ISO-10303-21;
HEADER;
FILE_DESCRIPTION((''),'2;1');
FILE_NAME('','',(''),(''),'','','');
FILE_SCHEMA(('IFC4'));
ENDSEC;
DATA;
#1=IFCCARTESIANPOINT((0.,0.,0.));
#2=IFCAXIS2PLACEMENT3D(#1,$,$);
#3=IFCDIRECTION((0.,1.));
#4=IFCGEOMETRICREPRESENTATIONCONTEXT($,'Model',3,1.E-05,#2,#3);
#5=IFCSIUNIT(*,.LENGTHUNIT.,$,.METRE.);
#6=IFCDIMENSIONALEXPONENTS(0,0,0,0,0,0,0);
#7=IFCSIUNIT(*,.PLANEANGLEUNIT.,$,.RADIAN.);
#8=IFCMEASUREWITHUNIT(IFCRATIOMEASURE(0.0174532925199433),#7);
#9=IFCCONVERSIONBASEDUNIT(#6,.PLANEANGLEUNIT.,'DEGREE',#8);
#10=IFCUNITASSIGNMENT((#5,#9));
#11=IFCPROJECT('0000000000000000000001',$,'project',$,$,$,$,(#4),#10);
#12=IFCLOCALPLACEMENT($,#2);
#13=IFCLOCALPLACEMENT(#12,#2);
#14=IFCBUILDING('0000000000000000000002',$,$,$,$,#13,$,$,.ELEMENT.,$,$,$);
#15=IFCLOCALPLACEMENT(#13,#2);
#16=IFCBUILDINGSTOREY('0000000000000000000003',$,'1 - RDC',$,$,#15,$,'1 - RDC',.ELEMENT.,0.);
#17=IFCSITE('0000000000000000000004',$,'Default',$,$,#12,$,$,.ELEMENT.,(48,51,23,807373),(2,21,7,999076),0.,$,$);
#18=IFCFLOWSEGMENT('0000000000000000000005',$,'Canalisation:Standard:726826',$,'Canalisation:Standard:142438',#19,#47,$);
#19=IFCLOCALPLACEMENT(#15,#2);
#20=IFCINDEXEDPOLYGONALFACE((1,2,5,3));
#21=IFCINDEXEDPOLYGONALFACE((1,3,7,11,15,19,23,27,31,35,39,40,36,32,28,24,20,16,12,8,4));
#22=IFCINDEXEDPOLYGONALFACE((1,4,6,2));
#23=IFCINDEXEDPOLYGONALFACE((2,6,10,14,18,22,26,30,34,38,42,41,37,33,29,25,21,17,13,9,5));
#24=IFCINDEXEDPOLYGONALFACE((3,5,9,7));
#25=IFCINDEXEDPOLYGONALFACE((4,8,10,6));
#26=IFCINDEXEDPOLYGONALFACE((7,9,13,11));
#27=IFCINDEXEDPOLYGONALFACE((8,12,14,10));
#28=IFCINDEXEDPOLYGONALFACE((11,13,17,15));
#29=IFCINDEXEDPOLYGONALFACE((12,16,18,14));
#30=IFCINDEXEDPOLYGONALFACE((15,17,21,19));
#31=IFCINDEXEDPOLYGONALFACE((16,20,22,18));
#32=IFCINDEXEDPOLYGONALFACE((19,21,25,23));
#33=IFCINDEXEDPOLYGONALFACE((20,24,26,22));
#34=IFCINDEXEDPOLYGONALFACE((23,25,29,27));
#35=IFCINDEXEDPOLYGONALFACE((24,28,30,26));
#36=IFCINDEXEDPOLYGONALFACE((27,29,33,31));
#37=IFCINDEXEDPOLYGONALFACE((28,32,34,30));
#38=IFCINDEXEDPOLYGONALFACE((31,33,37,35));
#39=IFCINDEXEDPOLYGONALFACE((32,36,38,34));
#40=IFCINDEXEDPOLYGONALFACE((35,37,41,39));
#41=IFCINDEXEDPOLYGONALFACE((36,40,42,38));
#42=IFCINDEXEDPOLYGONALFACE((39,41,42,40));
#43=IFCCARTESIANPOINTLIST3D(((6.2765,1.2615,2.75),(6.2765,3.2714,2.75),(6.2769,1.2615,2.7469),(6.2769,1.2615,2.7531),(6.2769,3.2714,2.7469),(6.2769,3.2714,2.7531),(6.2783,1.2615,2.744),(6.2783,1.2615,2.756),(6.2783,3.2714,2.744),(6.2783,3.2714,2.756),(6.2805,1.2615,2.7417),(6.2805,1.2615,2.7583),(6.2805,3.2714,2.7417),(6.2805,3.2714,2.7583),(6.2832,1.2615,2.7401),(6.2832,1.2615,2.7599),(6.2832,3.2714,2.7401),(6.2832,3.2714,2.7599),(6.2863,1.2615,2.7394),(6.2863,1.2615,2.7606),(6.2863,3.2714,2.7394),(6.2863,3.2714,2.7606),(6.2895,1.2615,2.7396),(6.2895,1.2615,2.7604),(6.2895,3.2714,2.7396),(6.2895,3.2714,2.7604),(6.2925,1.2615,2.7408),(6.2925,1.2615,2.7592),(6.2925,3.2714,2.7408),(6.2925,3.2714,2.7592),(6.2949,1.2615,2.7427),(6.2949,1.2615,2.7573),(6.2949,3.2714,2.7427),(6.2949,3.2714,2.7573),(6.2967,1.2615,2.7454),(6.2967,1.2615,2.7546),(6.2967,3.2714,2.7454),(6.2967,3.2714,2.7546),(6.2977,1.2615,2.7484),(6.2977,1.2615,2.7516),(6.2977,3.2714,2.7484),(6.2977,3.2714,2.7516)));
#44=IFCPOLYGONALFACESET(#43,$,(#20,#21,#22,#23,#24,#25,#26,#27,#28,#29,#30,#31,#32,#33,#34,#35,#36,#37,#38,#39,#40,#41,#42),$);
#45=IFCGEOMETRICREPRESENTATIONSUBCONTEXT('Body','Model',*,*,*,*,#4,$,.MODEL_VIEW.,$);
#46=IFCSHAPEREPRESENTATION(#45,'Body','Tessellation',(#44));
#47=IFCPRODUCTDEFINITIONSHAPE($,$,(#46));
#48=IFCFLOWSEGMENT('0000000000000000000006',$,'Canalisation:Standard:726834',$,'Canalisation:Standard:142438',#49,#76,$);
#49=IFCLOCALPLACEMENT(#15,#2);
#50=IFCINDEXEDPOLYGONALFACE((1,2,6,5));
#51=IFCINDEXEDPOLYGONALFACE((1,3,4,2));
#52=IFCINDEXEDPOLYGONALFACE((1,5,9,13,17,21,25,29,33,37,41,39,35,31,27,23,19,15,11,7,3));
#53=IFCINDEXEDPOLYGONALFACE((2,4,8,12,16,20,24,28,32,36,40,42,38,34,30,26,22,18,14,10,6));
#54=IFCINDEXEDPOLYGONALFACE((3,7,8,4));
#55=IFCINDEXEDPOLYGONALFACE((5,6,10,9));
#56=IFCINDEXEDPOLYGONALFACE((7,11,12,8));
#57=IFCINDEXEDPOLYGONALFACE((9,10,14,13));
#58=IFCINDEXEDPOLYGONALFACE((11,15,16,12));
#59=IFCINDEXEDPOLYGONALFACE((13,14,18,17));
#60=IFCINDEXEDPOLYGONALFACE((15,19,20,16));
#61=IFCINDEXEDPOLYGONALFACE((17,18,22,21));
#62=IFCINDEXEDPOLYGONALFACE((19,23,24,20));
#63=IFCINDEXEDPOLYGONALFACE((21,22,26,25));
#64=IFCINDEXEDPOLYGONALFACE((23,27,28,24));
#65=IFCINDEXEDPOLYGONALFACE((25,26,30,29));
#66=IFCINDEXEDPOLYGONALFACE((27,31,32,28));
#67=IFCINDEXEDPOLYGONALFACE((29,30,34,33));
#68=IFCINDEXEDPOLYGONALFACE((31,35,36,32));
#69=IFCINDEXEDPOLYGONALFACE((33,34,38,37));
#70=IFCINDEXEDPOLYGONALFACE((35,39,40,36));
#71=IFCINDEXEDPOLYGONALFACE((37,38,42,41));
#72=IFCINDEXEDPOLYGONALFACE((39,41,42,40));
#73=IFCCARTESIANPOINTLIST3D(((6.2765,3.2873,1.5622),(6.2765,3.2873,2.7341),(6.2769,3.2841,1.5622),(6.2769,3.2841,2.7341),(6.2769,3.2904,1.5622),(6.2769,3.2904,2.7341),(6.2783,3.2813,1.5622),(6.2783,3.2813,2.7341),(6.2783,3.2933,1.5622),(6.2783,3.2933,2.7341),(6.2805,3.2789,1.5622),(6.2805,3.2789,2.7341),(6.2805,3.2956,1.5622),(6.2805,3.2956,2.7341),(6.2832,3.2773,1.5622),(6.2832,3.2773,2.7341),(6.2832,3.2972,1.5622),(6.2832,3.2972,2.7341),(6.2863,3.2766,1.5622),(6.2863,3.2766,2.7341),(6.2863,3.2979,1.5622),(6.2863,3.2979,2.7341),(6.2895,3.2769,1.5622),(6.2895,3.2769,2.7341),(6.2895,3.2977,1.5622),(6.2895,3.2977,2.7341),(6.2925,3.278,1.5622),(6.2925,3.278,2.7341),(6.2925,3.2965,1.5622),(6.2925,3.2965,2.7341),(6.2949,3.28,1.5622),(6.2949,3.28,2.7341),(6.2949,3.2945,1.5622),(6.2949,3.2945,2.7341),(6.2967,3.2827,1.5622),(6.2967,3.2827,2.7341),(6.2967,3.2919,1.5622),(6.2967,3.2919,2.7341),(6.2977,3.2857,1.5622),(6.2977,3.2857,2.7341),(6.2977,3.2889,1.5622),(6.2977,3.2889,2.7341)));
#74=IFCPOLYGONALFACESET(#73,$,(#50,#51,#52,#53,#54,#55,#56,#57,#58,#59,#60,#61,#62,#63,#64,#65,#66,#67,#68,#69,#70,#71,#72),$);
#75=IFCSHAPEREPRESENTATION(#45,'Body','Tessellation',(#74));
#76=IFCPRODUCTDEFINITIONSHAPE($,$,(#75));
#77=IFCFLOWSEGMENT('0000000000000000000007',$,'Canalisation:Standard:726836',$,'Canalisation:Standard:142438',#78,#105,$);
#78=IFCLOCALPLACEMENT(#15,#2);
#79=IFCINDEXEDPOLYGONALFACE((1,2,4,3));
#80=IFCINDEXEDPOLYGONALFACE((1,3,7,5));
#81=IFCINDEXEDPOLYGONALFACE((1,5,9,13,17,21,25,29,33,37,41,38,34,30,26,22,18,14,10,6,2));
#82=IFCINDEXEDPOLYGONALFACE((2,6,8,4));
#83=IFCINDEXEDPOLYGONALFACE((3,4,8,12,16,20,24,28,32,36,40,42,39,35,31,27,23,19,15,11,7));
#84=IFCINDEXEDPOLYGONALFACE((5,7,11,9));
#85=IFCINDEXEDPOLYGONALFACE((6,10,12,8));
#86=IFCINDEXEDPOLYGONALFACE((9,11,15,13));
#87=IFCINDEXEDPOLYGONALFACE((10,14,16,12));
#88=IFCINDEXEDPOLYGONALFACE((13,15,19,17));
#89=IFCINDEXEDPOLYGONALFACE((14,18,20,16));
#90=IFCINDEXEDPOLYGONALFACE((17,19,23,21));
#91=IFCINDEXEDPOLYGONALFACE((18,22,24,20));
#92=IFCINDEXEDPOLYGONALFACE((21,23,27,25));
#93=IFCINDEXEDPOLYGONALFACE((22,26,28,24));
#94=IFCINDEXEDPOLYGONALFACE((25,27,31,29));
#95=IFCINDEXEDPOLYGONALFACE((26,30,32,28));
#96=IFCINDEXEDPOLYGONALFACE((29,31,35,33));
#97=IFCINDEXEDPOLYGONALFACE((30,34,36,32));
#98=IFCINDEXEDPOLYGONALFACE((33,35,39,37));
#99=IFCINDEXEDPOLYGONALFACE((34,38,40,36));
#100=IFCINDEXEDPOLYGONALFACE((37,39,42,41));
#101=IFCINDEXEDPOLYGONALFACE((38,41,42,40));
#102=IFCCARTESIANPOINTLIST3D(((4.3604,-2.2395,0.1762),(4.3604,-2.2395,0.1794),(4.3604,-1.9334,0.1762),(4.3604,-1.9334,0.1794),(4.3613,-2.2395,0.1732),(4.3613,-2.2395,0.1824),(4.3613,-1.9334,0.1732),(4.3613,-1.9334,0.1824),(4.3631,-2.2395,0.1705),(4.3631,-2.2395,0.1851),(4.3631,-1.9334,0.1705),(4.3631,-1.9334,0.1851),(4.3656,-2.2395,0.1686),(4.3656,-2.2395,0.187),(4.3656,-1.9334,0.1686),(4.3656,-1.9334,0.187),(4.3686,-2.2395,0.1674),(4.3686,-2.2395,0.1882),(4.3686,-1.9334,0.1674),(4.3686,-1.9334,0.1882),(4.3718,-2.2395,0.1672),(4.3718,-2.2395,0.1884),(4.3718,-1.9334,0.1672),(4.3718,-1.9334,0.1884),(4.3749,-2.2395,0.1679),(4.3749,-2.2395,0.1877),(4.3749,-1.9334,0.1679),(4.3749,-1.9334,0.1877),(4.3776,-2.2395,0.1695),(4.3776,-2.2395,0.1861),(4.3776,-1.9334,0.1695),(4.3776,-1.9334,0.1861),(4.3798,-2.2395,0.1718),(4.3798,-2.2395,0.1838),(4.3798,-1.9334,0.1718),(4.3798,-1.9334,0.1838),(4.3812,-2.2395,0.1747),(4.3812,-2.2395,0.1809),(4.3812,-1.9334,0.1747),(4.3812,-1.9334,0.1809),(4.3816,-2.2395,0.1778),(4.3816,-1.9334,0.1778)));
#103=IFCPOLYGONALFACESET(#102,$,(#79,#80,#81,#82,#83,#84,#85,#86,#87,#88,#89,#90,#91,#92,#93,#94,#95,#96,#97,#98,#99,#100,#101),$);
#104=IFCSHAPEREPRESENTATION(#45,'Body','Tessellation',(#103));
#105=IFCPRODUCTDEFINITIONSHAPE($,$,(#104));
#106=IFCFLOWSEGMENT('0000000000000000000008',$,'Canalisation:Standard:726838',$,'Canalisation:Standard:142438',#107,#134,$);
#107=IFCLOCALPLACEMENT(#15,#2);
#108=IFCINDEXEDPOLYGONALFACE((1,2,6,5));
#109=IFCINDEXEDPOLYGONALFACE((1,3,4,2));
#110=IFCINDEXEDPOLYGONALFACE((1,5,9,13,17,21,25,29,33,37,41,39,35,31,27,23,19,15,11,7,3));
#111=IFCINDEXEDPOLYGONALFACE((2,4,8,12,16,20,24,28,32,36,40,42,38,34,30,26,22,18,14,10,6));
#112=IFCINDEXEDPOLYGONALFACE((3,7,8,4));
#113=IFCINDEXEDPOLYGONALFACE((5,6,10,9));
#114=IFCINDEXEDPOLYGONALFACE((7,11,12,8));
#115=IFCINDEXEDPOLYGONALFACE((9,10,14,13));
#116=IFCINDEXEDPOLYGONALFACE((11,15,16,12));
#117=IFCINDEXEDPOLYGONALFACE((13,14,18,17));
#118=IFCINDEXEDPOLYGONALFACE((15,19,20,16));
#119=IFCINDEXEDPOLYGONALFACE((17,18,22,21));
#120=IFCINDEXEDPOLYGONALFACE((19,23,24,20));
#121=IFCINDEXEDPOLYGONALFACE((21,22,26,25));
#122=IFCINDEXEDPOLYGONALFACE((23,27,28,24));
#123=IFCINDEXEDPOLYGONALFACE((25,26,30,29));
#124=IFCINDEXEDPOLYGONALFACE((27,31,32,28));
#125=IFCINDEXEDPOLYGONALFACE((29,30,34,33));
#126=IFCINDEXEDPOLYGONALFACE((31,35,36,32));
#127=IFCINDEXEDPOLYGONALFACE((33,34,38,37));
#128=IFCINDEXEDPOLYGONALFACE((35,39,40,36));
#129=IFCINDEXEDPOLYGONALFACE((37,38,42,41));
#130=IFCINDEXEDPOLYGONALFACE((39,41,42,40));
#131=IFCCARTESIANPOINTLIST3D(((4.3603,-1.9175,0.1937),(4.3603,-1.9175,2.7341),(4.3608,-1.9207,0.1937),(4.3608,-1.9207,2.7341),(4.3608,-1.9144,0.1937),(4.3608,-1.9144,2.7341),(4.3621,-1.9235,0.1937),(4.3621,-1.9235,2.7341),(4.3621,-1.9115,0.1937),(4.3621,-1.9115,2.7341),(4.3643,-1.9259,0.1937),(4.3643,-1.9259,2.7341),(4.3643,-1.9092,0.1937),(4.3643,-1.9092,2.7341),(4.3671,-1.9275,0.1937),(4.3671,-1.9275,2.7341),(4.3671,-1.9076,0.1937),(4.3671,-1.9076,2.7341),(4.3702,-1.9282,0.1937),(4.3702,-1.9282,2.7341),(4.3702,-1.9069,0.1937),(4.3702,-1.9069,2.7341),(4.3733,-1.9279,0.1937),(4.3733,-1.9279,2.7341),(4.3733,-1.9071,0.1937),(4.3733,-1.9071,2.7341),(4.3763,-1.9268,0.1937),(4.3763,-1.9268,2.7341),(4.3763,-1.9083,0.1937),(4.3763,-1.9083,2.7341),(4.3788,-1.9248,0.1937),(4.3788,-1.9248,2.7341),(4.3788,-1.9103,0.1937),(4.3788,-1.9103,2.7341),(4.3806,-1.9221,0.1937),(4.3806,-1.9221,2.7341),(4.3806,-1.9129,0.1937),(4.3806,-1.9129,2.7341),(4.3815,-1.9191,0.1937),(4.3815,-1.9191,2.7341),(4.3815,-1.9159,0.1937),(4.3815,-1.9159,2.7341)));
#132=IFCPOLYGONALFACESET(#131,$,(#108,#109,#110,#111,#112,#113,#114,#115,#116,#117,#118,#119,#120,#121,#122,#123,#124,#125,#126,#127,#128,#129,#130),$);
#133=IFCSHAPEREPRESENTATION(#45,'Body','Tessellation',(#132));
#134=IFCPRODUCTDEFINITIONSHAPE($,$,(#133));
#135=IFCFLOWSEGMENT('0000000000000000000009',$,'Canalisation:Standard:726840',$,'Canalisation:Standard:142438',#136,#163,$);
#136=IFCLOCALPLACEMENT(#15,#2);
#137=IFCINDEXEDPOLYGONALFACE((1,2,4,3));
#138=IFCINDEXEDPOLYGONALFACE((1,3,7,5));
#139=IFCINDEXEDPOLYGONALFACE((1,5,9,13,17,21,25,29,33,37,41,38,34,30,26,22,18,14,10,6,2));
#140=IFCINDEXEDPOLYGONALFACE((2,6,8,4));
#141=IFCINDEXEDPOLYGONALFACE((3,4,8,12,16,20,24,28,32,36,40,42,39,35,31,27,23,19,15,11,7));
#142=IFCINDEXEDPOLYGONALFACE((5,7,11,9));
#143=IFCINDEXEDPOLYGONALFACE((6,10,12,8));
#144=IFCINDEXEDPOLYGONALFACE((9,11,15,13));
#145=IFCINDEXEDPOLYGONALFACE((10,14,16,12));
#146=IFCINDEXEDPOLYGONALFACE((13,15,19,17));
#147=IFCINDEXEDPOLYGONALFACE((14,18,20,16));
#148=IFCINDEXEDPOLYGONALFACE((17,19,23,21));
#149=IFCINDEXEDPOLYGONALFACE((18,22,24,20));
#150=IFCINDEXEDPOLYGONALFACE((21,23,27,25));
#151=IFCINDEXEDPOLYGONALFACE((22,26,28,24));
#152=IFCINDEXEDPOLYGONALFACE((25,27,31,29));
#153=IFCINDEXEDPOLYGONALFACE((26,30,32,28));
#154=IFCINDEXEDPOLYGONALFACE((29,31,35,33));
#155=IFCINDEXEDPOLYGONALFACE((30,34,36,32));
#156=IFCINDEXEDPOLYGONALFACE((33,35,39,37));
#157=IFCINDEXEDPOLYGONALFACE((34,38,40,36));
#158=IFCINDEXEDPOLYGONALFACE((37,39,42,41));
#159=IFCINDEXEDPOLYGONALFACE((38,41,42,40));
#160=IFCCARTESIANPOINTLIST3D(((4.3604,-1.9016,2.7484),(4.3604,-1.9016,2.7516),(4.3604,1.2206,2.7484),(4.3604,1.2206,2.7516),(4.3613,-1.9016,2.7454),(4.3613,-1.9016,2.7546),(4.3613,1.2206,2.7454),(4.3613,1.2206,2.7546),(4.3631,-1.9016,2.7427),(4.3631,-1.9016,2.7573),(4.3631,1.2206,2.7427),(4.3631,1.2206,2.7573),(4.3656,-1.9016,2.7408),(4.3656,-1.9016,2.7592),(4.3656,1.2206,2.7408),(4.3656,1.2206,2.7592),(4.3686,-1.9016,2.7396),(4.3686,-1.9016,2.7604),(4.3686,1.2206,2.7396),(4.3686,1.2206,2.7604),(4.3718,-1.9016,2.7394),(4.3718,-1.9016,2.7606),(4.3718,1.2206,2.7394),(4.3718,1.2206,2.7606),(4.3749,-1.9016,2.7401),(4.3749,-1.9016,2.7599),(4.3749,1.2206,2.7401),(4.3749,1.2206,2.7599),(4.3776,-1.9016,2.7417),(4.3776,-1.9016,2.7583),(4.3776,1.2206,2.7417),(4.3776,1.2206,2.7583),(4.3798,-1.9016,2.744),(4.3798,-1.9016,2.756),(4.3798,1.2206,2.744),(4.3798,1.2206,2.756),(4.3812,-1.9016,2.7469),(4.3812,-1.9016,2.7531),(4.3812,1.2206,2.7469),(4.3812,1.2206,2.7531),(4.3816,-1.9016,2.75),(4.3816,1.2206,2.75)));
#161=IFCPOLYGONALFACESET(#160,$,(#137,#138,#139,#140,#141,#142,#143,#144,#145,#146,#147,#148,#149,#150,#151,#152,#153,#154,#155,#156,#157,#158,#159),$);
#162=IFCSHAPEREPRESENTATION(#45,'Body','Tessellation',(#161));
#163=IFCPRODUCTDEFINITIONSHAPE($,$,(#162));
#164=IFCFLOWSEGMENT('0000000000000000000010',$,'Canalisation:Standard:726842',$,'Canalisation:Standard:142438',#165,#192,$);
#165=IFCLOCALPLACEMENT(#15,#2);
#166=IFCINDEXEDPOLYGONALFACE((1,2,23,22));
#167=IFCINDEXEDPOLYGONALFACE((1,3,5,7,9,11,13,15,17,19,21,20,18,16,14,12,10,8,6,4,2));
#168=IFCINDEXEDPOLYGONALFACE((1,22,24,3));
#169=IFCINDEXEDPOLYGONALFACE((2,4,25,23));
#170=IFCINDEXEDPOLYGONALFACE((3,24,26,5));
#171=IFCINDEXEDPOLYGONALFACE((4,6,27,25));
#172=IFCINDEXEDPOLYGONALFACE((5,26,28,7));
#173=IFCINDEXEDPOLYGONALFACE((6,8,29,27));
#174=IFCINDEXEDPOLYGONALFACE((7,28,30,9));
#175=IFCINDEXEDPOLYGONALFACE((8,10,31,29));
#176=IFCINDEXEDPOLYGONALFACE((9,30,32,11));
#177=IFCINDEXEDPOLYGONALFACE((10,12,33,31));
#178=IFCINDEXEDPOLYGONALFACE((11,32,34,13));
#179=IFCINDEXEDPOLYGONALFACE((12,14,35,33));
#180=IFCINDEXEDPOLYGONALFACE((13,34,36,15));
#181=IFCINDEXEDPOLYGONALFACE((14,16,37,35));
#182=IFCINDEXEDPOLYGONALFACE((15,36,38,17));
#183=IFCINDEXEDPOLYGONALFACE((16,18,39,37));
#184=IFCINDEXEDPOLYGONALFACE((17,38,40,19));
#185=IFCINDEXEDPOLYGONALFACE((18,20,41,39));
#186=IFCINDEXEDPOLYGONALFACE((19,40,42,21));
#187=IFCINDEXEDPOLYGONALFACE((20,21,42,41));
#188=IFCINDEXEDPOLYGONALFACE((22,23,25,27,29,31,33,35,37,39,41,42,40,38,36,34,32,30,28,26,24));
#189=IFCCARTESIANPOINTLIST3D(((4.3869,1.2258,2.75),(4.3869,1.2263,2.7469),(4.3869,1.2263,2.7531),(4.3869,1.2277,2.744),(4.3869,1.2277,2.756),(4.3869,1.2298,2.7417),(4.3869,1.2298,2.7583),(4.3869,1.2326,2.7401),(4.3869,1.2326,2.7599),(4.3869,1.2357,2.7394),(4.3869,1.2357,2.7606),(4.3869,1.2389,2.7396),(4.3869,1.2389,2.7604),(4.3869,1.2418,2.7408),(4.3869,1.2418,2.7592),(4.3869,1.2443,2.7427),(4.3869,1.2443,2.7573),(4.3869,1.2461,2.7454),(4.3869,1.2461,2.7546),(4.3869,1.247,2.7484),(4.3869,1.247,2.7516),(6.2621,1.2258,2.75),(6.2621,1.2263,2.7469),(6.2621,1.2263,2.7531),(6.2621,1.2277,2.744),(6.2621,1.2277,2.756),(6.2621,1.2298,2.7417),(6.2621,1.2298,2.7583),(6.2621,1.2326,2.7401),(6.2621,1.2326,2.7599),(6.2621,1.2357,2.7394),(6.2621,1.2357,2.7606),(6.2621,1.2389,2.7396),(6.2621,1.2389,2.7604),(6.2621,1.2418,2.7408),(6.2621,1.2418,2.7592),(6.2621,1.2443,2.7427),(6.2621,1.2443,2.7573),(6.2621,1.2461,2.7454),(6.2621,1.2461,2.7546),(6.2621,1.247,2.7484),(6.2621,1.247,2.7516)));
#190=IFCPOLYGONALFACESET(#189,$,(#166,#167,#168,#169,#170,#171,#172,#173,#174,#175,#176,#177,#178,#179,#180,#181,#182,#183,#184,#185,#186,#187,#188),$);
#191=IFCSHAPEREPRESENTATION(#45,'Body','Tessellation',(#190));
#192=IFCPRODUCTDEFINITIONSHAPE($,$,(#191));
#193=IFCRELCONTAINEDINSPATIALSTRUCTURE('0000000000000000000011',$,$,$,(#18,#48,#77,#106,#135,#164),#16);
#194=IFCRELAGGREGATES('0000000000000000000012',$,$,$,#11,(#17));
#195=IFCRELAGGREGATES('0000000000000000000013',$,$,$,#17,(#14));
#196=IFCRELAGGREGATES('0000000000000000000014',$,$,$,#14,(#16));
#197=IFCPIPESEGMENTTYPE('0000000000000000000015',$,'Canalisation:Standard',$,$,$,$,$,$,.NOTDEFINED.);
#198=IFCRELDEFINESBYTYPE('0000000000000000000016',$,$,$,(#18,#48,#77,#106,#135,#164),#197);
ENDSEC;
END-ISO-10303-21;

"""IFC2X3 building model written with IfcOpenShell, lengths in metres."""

from ifc_helpers import new_model, entity, si_unit, converted_unit, direction, frame, frame_2d, origin, origin_2d_with_axis, place, context, subcontext, project, spatial, circle, extrude, type_object, element, save


model = new_model("IFC2X3")

# Units and contexts
model_context = context("Model", 3, precision=1e-05, world=origin(), true_north=direction((0.0, 1.0)))
body_context = subcontext(model_context, "Body", "Model", "MODEL_VIEW")
ifc_project = project(units=[si_unit("LENGTHUNIT", "METRE"), converted_unit("PLANEANGLEUNIT", "DEGREE", entity("IfcRatioMeasure", 0.0174532925199433), si_unit("PLANEANGLEUNIT", "RADIAN"), dimensions=[0, 0, 0, 0, 0, 0, 0])], contexts=[model_context])

# Site, building, storey
site_placement = place(None, origin())
site = spatial("IfcSite", under=ifc_project, at=site_placement, Name="Default", CompositionType="ELEMENT", RefLatitude=(48, 51, 23, 807373), RefLongitude=(2, 21, 7, 999076), RefElevation=0.0)
building_placement = place(site_placement, origin())
building = spatial("IfcBuilding", under=site, at=building_placement, CompositionType="ELEMENT")
storey_placement = place(building_placement, origin())
storey = spatial("IfcBuildingStorey", under=building, at=storey_placement, Name="1 - RDC", LongName="1 - RDC", CompositionType="ELEMENT", Elevation=0.0)

# Flow segments
pipe_segment_type = type_object("IfcPipeSegmentType", Name="Canalisation:Standard", PredefinedType="NOTDEFINED")
flow_segment_1_placement = place(storey_placement, origin())
element("IfcFlowSegment", 1, at=flow_segment_1_placement, inside=storey, type_object=pipe_segment_type, Name="Canalisation:Standard:726826", ObjectType="Canalisation:Standard:142438", context=body_context, shape_type="SweptSolid", body=[
    extrude(circle(Radius=0.0107, at=frame_2d((0.0, 0.0), x_axis=(1.0, 0.0))), frame((6.2871, 1.2615, 2.75), z_axis=(0.0, 1.0, 0.0), x_axis=(-1.0, 0.0, 0.0)), (0.0, 0.0, 1.0), 2.0099),
])
flow_segment_2_placement = place(storey_placement, origin())
element("IfcFlowSegment", 2, at=flow_segment_2_placement, inside=storey, type_object=pipe_segment_type, Name="Canalisation:Standard:726834", ObjectType="Canalisation:Standard:142438", context=body_context, shape_type="SweptSolid", body=[
    extrude(circle(Radius=0.0107, at=origin_2d_with_axis()), frame((6.2871, 3.2873, 1.5622), z_axis=(0.0, 0.0, 1.0), x_axis=(-1.0, 0.0, 0.0)), (0.0, 0.0, 1.0), 1.1719),
])
flow_segment_3_placement = place(storey_placement, origin())
element("IfcFlowSegment", 3, at=flow_segment_3_placement, inside=storey, type_object=pipe_segment_type, Name="Canalisation:Standard:726836", ObjectType="Canalisation:Standard:142438", context=body_context, shape_type="SweptSolid", body=[
    extrude(circle(Radius=0.0107, at=origin_2d_with_axis()), frame((4.371, -2.2395, 0.1778), z_axis=(0.0, 1.0, 0.0), x_axis=(1.0, 0.0, 0.0)), (0.0, 0.0, 1.0), 0.3061),
])
flow_segment_4_placement = place(storey_placement, origin())
element("IfcFlowSegment", 4, at=flow_segment_4_placement, inside=storey, type_object=pipe_segment_type, Name="Canalisation:Standard:726838", ObjectType="Canalisation:Standard:142438", context=body_context, shape_type="SweptSolid", body=[
    extrude(circle(Radius=0.0107, at=origin_2d_with_axis()), frame((4.371, -1.9175, 0.1937), z_axis=(0.0, 0.0, 1.0), x_axis=(-1.0, 0.0, 0.0)), (0.0, 0.0, 1.0), 2.5404),
])
flow_segment_5_placement = place(storey_placement, origin())
element("IfcFlowSegment", 5, at=flow_segment_5_placement, inside=storey, type_object=pipe_segment_type, Name="Canalisation:Standard:726840", ObjectType="Canalisation:Standard:142438", context=body_context, shape_type="SweptSolid", body=[
    extrude(circle(Radius=0.0107, at=origin_2d_with_axis()), frame((4.371, -1.9016, 2.75), z_axis=(0.0, 1.0, 0.0), x_axis=(1.0, 0.0, 0.0)), (0.0, 0.0, 1.0), 3.1222),
])
flow_segment_6_placement = place(storey_placement, origin())
element("IfcFlowSegment", 6, at=flow_segment_6_placement, inside=storey, type_object=pipe_segment_type, Name="Canalisation:Standard:726842", ObjectType="Canalisation:Standard:142438", context=body_context, shape_type="SweptSolid", body=[
    extrude(circle(Radius=0.0107, at=origin_2d_with_axis()), frame((4.3869, 1.2365, 2.75), z_axis=(1.0, 0.0, 0.0), x_axis=(0.0, -1.0, 0.0)), (0.0, 0.0, 1.0), 1.8753),
])

save(model, "model.ifc")
